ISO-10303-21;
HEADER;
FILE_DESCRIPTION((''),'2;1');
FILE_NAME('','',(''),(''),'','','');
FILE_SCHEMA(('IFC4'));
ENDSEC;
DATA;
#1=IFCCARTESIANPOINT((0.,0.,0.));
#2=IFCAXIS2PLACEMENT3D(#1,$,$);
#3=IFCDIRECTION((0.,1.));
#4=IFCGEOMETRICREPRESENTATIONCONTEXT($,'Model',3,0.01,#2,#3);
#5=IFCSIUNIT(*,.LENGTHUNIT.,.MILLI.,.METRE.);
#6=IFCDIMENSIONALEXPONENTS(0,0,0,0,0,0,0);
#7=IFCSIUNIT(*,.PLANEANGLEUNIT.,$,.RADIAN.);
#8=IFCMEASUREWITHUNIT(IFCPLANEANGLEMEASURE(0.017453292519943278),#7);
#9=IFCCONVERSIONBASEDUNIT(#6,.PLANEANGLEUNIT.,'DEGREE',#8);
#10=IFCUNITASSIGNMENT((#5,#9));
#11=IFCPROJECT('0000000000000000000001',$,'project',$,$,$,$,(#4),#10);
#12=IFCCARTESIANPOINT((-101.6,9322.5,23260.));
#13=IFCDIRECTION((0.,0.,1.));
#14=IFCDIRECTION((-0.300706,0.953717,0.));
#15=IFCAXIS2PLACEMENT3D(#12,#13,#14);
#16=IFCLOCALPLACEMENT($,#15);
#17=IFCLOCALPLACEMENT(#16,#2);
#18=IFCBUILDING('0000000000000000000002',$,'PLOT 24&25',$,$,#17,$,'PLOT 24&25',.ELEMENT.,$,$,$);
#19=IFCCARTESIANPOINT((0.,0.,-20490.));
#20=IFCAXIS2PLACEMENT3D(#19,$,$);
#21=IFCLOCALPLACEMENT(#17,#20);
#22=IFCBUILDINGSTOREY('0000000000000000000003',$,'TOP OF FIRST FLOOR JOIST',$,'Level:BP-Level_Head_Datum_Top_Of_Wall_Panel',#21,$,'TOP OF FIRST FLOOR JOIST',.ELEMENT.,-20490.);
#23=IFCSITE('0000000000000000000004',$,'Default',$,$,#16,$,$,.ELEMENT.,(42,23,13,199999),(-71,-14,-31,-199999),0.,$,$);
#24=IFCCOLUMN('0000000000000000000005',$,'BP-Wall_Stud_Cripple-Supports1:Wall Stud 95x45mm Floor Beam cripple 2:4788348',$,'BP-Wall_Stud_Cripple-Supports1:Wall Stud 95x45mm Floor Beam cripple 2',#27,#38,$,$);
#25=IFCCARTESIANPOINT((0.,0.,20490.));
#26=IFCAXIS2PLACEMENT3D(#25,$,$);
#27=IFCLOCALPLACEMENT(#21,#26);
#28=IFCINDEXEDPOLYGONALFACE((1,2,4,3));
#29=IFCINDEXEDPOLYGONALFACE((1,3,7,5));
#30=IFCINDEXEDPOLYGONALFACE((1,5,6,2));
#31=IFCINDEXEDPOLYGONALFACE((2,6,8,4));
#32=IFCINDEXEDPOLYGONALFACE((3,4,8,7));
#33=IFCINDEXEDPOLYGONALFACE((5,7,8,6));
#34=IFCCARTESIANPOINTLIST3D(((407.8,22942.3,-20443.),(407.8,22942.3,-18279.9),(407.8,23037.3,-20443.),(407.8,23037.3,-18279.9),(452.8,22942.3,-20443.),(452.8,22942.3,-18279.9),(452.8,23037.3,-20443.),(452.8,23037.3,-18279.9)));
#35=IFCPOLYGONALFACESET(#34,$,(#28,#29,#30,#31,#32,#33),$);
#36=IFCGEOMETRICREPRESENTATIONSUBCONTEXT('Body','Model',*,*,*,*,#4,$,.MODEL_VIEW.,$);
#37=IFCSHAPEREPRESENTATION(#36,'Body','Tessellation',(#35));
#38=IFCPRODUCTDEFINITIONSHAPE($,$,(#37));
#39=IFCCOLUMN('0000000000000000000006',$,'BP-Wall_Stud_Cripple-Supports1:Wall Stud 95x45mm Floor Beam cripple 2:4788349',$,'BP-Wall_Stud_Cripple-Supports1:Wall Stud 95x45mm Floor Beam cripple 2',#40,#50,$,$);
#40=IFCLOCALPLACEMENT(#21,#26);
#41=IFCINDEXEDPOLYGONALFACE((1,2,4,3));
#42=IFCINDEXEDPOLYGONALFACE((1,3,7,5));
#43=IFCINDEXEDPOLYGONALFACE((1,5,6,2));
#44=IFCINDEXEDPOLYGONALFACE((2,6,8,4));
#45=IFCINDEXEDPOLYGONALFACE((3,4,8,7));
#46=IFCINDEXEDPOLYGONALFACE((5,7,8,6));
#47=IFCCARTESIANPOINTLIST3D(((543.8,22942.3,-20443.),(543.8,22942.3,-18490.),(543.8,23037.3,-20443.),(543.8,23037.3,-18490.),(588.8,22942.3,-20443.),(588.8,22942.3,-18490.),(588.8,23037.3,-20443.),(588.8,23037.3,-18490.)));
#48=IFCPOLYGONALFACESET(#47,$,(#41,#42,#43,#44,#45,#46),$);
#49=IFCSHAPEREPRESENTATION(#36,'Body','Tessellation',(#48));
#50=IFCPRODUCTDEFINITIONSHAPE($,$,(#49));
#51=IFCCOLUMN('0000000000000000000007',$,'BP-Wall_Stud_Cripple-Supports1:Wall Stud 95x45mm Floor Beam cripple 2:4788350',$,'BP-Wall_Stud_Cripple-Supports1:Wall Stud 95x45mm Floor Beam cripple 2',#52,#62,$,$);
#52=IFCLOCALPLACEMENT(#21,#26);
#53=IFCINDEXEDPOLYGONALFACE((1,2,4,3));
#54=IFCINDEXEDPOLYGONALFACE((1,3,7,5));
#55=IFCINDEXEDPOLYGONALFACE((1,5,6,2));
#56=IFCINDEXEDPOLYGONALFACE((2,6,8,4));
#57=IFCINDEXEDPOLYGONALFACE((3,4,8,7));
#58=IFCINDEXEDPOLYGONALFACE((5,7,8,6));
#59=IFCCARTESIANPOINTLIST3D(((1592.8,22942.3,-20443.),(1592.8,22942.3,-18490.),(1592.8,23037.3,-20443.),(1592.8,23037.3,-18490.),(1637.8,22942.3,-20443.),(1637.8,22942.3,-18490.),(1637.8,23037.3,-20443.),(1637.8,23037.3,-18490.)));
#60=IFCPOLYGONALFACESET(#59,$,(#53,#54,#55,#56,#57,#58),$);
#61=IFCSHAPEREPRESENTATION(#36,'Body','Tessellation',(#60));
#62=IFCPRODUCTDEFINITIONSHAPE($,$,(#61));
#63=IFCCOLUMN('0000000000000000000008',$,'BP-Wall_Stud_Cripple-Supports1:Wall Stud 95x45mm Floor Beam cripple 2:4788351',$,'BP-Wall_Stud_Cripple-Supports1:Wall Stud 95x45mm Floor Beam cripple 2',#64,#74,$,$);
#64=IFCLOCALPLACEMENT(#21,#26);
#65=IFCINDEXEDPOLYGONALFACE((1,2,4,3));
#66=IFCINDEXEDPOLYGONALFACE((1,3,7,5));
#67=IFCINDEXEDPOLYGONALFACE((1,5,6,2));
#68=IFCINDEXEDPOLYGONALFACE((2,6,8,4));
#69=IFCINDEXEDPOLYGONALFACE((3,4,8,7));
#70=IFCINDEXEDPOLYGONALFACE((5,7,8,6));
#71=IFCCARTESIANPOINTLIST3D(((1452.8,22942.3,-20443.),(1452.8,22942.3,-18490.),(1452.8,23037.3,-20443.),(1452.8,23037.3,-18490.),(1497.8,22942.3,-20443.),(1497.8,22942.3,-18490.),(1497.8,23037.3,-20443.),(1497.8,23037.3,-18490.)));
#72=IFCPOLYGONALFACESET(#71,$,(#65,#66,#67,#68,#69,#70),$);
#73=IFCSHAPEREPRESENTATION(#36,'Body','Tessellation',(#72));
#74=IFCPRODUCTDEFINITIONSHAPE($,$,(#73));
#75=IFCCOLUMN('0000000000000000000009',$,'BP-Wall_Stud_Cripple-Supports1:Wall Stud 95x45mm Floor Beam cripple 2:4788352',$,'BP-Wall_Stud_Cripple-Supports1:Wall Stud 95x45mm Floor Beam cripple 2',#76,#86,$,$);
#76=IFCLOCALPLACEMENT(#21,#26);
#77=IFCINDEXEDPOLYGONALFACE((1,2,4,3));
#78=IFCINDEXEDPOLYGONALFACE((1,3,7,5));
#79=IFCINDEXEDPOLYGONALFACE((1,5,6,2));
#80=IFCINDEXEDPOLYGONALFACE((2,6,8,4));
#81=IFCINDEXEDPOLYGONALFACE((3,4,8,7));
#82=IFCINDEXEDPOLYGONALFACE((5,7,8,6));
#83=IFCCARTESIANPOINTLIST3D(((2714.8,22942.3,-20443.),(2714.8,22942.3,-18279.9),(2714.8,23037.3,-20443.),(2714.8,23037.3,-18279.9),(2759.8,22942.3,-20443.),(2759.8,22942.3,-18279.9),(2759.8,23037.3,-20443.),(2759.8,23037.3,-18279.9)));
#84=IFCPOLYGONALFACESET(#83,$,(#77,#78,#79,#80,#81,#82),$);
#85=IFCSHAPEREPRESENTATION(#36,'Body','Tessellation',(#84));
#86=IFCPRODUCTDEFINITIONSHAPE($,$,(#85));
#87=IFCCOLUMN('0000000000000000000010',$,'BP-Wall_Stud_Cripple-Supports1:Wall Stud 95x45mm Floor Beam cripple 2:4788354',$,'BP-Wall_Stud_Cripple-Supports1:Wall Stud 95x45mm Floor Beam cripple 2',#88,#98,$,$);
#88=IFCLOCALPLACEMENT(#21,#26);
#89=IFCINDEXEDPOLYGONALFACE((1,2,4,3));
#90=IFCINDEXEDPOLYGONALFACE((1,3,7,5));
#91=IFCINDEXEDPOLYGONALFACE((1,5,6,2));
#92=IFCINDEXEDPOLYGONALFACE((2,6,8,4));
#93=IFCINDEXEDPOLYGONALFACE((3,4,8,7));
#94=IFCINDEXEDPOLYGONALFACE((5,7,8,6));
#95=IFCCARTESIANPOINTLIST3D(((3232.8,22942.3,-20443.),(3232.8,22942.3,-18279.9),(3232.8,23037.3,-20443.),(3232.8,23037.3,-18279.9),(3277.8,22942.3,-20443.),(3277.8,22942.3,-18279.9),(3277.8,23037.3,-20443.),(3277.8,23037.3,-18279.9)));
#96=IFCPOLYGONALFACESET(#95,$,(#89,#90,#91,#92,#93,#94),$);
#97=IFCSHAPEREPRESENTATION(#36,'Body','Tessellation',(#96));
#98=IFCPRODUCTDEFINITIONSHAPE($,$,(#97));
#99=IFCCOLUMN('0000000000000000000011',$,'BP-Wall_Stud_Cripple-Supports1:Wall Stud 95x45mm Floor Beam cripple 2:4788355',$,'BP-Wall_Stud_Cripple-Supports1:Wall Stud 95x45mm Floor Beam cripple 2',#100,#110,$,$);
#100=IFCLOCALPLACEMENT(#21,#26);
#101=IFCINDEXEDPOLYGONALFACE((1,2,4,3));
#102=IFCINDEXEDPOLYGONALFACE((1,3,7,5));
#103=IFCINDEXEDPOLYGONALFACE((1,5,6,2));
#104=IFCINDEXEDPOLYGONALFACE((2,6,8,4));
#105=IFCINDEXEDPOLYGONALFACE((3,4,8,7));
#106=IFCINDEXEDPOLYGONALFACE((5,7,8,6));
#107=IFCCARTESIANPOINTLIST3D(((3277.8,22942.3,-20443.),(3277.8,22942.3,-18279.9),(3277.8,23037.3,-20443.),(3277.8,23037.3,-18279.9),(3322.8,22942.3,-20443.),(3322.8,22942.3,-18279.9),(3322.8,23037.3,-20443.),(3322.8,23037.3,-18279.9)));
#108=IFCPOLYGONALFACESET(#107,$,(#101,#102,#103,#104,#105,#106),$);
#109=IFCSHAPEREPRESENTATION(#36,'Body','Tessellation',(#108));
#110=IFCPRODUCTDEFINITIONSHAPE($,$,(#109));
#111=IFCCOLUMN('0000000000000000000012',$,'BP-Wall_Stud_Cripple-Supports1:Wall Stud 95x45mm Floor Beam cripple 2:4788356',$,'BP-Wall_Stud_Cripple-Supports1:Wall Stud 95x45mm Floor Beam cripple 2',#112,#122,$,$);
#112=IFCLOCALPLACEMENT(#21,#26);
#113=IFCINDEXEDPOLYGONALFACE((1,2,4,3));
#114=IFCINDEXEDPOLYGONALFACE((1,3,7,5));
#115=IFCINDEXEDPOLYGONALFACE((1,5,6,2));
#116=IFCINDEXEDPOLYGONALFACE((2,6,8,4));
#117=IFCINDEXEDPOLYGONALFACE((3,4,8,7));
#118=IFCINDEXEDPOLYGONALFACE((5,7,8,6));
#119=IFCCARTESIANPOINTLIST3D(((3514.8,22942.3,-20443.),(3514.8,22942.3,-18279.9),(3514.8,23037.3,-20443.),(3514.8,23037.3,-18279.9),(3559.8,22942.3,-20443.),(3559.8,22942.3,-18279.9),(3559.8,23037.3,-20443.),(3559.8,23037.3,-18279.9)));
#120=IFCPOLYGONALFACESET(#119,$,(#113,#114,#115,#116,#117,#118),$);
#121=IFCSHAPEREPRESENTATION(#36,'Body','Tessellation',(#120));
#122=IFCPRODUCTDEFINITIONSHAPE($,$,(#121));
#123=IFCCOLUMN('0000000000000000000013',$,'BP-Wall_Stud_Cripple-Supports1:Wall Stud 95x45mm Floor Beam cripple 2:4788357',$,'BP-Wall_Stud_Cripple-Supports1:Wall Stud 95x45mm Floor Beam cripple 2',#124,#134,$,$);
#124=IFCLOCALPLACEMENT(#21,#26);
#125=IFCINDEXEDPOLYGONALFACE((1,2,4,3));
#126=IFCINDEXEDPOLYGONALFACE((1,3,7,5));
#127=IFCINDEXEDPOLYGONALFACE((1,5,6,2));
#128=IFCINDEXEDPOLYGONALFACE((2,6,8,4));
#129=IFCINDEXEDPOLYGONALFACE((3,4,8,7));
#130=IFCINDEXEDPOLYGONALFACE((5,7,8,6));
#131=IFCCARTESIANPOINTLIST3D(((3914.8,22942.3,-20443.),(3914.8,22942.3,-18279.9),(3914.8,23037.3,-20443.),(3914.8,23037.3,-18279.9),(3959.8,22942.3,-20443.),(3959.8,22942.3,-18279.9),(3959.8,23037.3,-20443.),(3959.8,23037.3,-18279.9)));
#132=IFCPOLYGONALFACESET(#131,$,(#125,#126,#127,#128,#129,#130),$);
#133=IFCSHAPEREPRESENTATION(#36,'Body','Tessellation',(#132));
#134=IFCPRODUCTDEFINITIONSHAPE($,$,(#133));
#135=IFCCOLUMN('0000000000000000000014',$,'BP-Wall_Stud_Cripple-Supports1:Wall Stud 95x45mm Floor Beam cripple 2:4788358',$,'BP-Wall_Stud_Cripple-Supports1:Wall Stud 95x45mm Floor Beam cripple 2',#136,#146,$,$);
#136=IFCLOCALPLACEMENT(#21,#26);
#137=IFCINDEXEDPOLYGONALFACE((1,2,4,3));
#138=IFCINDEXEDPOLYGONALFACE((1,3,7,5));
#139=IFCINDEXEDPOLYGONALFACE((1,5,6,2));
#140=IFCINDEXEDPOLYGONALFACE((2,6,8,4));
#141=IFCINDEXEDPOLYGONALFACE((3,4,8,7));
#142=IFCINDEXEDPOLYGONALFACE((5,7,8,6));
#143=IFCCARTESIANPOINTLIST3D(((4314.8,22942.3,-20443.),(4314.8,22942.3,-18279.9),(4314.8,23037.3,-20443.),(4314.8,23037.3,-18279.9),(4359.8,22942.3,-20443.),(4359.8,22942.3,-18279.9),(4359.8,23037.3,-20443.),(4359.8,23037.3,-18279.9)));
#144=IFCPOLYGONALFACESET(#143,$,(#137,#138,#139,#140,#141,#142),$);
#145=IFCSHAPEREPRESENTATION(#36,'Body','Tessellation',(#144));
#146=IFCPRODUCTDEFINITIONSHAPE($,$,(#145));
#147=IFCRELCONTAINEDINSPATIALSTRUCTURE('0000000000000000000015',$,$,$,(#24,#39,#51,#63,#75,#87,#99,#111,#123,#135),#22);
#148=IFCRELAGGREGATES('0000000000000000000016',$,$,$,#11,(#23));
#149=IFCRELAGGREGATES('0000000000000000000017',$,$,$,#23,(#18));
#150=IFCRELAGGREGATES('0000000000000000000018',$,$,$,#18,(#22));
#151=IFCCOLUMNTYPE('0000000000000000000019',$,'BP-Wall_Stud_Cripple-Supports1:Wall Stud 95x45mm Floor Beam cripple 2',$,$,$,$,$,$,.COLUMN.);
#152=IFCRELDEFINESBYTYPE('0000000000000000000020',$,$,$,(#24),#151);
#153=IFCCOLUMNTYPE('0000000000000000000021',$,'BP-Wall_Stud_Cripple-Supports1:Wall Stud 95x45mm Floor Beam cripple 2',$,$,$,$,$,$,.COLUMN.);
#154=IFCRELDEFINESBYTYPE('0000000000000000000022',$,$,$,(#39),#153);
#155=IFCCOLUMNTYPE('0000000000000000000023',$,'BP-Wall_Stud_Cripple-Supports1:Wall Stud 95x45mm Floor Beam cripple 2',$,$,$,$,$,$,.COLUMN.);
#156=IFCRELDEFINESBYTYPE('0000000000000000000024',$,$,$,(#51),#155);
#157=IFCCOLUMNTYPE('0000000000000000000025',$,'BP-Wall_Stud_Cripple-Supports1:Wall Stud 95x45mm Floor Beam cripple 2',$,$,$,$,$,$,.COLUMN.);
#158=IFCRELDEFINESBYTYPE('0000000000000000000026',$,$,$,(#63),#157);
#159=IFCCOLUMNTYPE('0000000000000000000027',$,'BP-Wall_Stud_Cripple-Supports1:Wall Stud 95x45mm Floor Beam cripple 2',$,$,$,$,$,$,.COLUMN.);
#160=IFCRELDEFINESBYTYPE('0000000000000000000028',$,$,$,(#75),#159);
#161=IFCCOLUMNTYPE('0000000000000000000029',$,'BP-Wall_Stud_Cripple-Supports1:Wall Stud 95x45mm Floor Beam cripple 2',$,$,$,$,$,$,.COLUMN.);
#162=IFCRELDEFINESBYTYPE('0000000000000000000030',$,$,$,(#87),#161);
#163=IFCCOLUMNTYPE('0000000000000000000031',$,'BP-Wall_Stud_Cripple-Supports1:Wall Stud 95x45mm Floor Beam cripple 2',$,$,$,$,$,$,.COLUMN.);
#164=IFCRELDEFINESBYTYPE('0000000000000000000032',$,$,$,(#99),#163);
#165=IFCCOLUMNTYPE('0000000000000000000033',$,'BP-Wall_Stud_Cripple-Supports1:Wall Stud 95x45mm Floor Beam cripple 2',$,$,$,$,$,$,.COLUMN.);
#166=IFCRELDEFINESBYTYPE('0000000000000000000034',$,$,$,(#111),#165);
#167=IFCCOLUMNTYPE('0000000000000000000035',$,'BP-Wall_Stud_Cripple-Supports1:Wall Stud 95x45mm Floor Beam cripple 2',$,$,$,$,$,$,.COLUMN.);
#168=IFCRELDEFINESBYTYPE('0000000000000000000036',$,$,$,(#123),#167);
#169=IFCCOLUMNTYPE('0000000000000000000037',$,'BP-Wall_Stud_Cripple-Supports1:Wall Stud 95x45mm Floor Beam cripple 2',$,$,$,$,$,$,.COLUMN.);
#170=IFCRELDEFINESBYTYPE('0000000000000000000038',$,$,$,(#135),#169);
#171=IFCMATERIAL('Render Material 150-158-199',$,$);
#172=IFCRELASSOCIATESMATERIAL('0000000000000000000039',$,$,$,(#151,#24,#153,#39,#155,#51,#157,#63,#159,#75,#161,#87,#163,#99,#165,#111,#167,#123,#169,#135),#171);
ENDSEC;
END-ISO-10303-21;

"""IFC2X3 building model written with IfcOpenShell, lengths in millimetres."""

from ifc_helpers import new_model, entity, si_unit, converted_unit, direction, frame, frame_2d, origin, place, context, subcontext, project, spatial, rectangle, extrude, source, transform, mapped, material, type_object, type_shapes, element, save


model = new_model("IFC2X3")

# Units and contexts
model_context = context("Model", 3, precision=0.01, world=origin(), true_north=direction((0.0, 1.0)))
body_context = subcontext(model_context, "Body", "Model", "MODEL_VIEW")
ifc_project = project(units=[si_unit("LENGTHUNIT", "METRE", prefix="MILLI"), converted_unit("PLANEANGLEUNIT", "DEGREE", entity("IfcPlaneAngleMeasure", 0.017453292519943278), si_unit("PLANEANGLEUNIT", "RADIAN"), dimensions=[0, 0, 0, 0, 0, 0, 0])], contexts=[model_context])

# Site, building, storey
site_placement = place(None, frame((-101.6, 9322.5, 23260.0), z_axis=(0.0, 0.0, 1.0), x_axis=(-0.300706, 0.953717, 0.0)))
site = spatial("IfcSite", under=ifc_project, at=site_placement, Name="Default", CompositionType="ELEMENT", RefLatitude=(42, 23, 13, 199999), RefLongitude=(-71, -14, -31, -199999), RefElevation=0.0)
building_placement = place(site_placement, origin())
building = spatial("IfcBuilding", under=site, at=building_placement, Name="PLOT 24&25", LongName="PLOT 24&25", CompositionType="ELEMENT")
storey_placement = place(building_placement, frame((0.0, 0.0, -20490.0)))
storey = spatial("IfcBuildingStorey", under=building, at=storey_placement, Name="TOP OF FIRST FLOOR JOIST", ObjectType="Level:BP-Level_Head_Datum_Top_Of_Wall_Panel", LongName="TOP OF FIRST FLOOR JOIST", CompositionType="ELEMENT", Elevation=-20490.0)

# Columns
ifc_material_1 = material(Name="Render Material 150-158-199")
column_type_1 = type_object("IfcColumnType", Name="BP-Wall_Stud_Cripple-Supports1:Wall Stud 95x45mm Floor Beam cripple 2", PredefinedType="COLUMN", material=ifc_material_1)
shared_shape_1 = source(origin(), body_context, "Body", "SweptSolid", [
    extrude(rectangle(XDim=45.0, YDim=95.0, at=frame_2d((0.0, 0.0), x_axis=(1.0, 0.0))), frame((430.3, 22989.8, -20443.0), z_axis=(0.0, 0.0, 1.0), x_axis=(-1.0, 0.0, 0.0)), (0.0, 0.0, 1.0), 2163.1),
])
type_shapes(column_type_1, [shared_shape_1])
column_1_placement = place(storey_placement, frame((0.0, 0.0, 20490.0)))
element("IfcColumn", 1, at=column_1_placement, inside=storey, type_object=column_type_1, material=ifc_material_1, Name="BP-Wall_Stud_Cripple-Supports1:Wall Stud 95x45mm Floor Beam cripple 2:4788348", ObjectType="BP-Wall_Stud_Cripple-Supports1:Wall Stud 95x45mm Floor Beam cripple 2", context=body_context, shape_type="MappedRepresentation", body=[
    mapped(shared_shape_1, transform((0.0, 0.0, 0.0), scale=1.0)),
])
column_type_2 = type_object("IfcColumnType", Name="BP-Wall_Stud_Cripple-Supports1:Wall Stud 95x45mm Floor Beam cripple 2", PredefinedType="COLUMN", material=ifc_material_1)
shared_shape_2 = source(origin(), body_context, "Body", "SweptSolid", [
    extrude(rectangle(XDim=45.0, YDim=95.0, at=frame_2d((0.0, 0.0), x_axis=(1.0, 0.0))), frame((566.3, 22989.8, -20443.0), z_axis=(0.0, 0.0, 1.0), x_axis=(-1.0, 0.0, 0.0)), (0.0, 0.0, 1.0), 1953.0),
])
type_shapes(column_type_2, [shared_shape_2])
column_2_placement = place(storey_placement, frame((0.0, 0.0, 20490.0)))
element("IfcColumn", 2, at=column_2_placement, inside=storey, type_object=column_type_2, material=ifc_material_1, Name="BP-Wall_Stud_Cripple-Supports1:Wall Stud 95x45mm Floor Beam cripple 2:4788349", ObjectType="BP-Wall_Stud_Cripple-Supports1:Wall Stud 95x45mm Floor Beam cripple 2", context=body_context, shape_type="MappedRepresentation", body=[
    mapped(shared_shape_2, transform((0.0, 0.0, 0.0), scale=1.0)),
])
column_type_3 = type_object("IfcColumnType", Name="BP-Wall_Stud_Cripple-Supports1:Wall Stud 95x45mm Floor Beam cripple 2", PredefinedType="COLUMN", material=ifc_material_1)
shared_shape_3 = source(origin(), body_context, "Body", "SweptSolid", [
    extrude(rectangle(XDim=45.0, YDim=95.0, at=frame_2d((0.0, 0.0), x_axis=(1.0, 0.0))), frame((1615.3, 22989.8, -20443.0), z_axis=(0.0, 0.0, 1.0), x_axis=(-1.0, 0.0, 0.0)), (0.0, 0.0, 1.0), 1953.0),
])
type_shapes(column_type_3, [shared_shape_3])
column_3_placement = place(storey_placement, frame((0.0, 0.0, 20490.0)))
element("IfcColumn", 3, at=column_3_placement, inside=storey, type_object=column_type_3, material=ifc_material_1, Name="BP-Wall_Stud_Cripple-Supports1:Wall Stud 95x45mm Floor Beam cripple 2:4788350", ObjectType="BP-Wall_Stud_Cripple-Supports1:Wall Stud 95x45mm Floor Beam cripple 2", context=body_context, shape_type="MappedRepresentation", body=[
    mapped(shared_shape_3, transform((0.0, 0.0, 0.0), scale=1.0)),
])
column_type_4 = type_object("IfcColumnType", Name="BP-Wall_Stud_Cripple-Supports1:Wall Stud 95x45mm Floor Beam cripple 2", PredefinedType="COLUMN", material=ifc_material_1)
shared_shape_4 = source(origin(), body_context, "Body", "SweptSolid", [
    extrude(rectangle(XDim=45.0, YDim=95.0, at=frame_2d((0.0, 0.0), x_axis=(1.0, 0.0))), frame((1475.3, 22989.8, -20443.0), z_axis=(0.0, 0.0, 1.0), x_axis=(-1.0, 0.0, 0.0)), (0.0, 0.0, 1.0), 1953.0),
])
type_shapes(column_type_4, [shared_shape_4])
column_4_placement = place(storey_placement, frame((0.0, 0.0, 20490.0)))
element("IfcColumn", 4, at=column_4_placement, inside=storey, type_object=column_type_4, material=ifc_material_1, Name="BP-Wall_Stud_Cripple-Supports1:Wall Stud 95x45mm Floor Beam cripple 2:4788351", ObjectType="BP-Wall_Stud_Cripple-Supports1:Wall Stud 95x45mm Floor Beam cripple 2", context=body_context, shape_type="MappedRepresentation", body=[
    mapped(shared_shape_4, transform((0.0, 0.0, 0.0), scale=1.0)),
])
column_type_5 = type_object("IfcColumnType", Name="BP-Wall_Stud_Cripple-Supports1:Wall Stud 95x45mm Floor Beam cripple 2", PredefinedType="COLUMN", material=ifc_material_1)
shared_shape_5 = source(origin(), body_context, "Body", "SweptSolid", [
    extrude(rectangle(XDim=45.0, YDim=95.0, at=frame_2d((0.0, 0.0), x_axis=(1.0, 0.0))), frame((2737.3, 22989.8, -20443.0), z_axis=(0.0, 0.0, 1.0), x_axis=(-1.0, 0.0, 0.0)), (0.0, 0.0, 1.0), 2163.1),
])
type_shapes(column_type_5, [shared_shape_5])
column_5_placement = place(storey_placement, frame((0.0, 0.0, 20490.0)))
element("IfcColumn", 5, at=column_5_placement, inside=storey, type_object=column_type_5, material=ifc_material_1, Name="BP-Wall_Stud_Cripple-Supports1:Wall Stud 95x45mm Floor Beam cripple 2:4788352", ObjectType="BP-Wall_Stud_Cripple-Supports1:Wall Stud 95x45mm Floor Beam cripple 2", context=body_context, shape_type="MappedRepresentation", body=[
    mapped(shared_shape_5, transform((0.0, 0.0, 0.0), scale=1.0)),
])
column_type_6 = type_object("IfcColumnType", Name="BP-Wall_Stud_Cripple-Supports1:Wall Stud 95x45mm Floor Beam cripple 2", PredefinedType="COLUMN", material=ifc_material_1)
shared_shape_6 = source(origin(), body_context, "Body", "SweptSolid", [
    extrude(rectangle(XDim=45.0, YDim=95.0, at=frame_2d((0.0, 0.0), x_axis=(1.0, 0.0))), frame((3255.3, 22989.8, -20443.0), z_axis=(0.0, 0.0, 1.0), x_axis=(-1.0, 0.0, 0.0)), (0.0, 0.0, 1.0), 2163.1),
])
type_shapes(column_type_6, [shared_shape_6])
column_6_placement = place(storey_placement, frame((0.0, 0.0, 20490.0)))
element("IfcColumn", 6, at=column_6_placement, inside=storey, type_object=column_type_6, material=ifc_material_1, Name="BP-Wall_Stud_Cripple-Supports1:Wall Stud 95x45mm Floor Beam cripple 2:4788354", ObjectType="BP-Wall_Stud_Cripple-Supports1:Wall Stud 95x45mm Floor Beam cripple 2", context=body_context, shape_type="MappedRepresentation", body=[
    mapped(shared_shape_6, transform((0.0, 0.0, 0.0), scale=1.0)),
])
column_type_7 = type_object("IfcColumnType", Name="BP-Wall_Stud_Cripple-Supports1:Wall Stud 95x45mm Floor Beam cripple 2", PredefinedType="COLUMN", material=ifc_material_1)
shared_shape_7 = source(origin(), body_context, "Body", "SweptSolid", [
    extrude(rectangle(XDim=45.0, YDim=95.0, at=frame_2d((0.0, 0.0), x_axis=(1.0, 0.0))), frame((3300.3, 22989.8, -20443.0), z_axis=(0.0, 0.0, 1.0), x_axis=(-1.0, 0.0, 0.0)), (0.0, 0.0, 1.0), 2163.1),
])
type_shapes(column_type_7, [shared_shape_7])
column_7_placement = place(storey_placement, frame((0.0, 0.0, 20490.0)))
element("IfcColumn", 7, at=column_7_placement, inside=storey, type_object=column_type_7, material=ifc_material_1, Name="BP-Wall_Stud_Cripple-Supports1:Wall Stud 95x45mm Floor Beam cripple 2:4788355", ObjectType="BP-Wall_Stud_Cripple-Supports1:Wall Stud 95x45mm Floor Beam cripple 2", context=body_context, shape_type="MappedRepresentation", body=[
    mapped(shared_shape_7, transform((0.0, 0.0, 0.0), scale=1.0)),
])
column_type_8 = type_object("IfcColumnType", Name="BP-Wall_Stud_Cripple-Supports1:Wall Stud 95x45mm Floor Beam cripple 2", PredefinedType="COLUMN", material=ifc_material_1)
shared_shape_8 = source(origin(), body_context, "Body", "SweptSolid", [
    extrude(rectangle(XDim=45.0, YDim=95.0, at=frame_2d((0.0, 0.0), x_axis=(1.0, 0.0))), frame((3537.3, 22989.8, -20443.0), z_axis=(0.0, 0.0, 1.0), x_axis=(-1.0, 0.0, 0.0)), (0.0, 0.0, 1.0), 2163.1),
])
type_shapes(column_type_8, [shared_shape_8])
column_8_placement = place(storey_placement, frame((0.0, 0.0, 20490.0)))
element("IfcColumn", 8, at=column_8_placement, inside=storey, type_object=column_type_8, material=ifc_material_1, Name="BP-Wall_Stud_Cripple-Supports1:Wall Stud 95x45mm Floor Beam cripple 2:4788356", ObjectType="BP-Wall_Stud_Cripple-Supports1:Wall Stud 95x45mm Floor Beam cripple 2", context=body_context, shape_type="MappedRepresentation", body=[
    mapped(shared_shape_8, transform((0.0, 0.0, 0.0), scale=1.0)),
])
column_type_9 = type_object("IfcColumnType", Name="BP-Wall_Stud_Cripple-Supports1:Wall Stud 95x45mm Floor Beam cripple 2", PredefinedType="COLUMN", material=ifc_material_1)
shared_shape_9 = source(origin(), body_context, "Body", "SweptSolid", [
    extrude(rectangle(XDim=45.0, YDim=95.0, at=frame_2d((0.0, 0.0), x_axis=(1.0, 0.0))), frame((3937.3, 22989.8, -20443.0), z_axis=(0.0, 0.0, 1.0), x_axis=(-1.0, 0.0, 0.0)), (0.0, 0.0, 1.0), 2163.1),
])
type_shapes(column_type_9, [shared_shape_9])
column_9_placement = place(storey_placement, frame((0.0, 0.0, 20490.0)))
element("IfcColumn", 9, at=column_9_placement, inside=storey, type_object=column_type_9, material=ifc_material_1, Name="BP-Wall_Stud_Cripple-Supports1:Wall Stud 95x45mm Floor Beam cripple 2:4788357", ObjectType="BP-Wall_Stud_Cripple-Supports1:Wall Stud 95x45mm Floor Beam cripple 2", context=body_context, shape_type="MappedRepresentation", body=[
    mapped(shared_shape_9, transform((0.0, 0.0, 0.0), scale=1.0)),
])
column_type_10 = type_object("IfcColumnType", Name="BP-Wall_Stud_Cripple-Supports1:Wall Stud 95x45mm Floor Beam cripple 2", PredefinedType="COLUMN", material=ifc_material_1)
shared_shape_10 = source(origin(), body_context, "Body", "SweptSolid", [
    extrude(rectangle(XDim=45.0, YDim=95.0, at=frame_2d((0.0, 0.0), x_axis=(1.0, 0.0))), frame((4337.3, 22989.8, -20443.0), z_axis=(0.0, 0.0, 1.0), x_axis=(-1.0, 0.0, 0.0)), (0.0, 0.0, 1.0), 2163.1),
])
type_shapes(column_type_10, [shared_shape_10])
column_10_placement = place(storey_placement, frame((0.0, 0.0, 20490.0)))
element("IfcColumn", 10, at=column_10_placement, inside=storey, type_object=column_type_10, material=ifc_material_1, Name="BP-Wall_Stud_Cripple-Supports1:Wall Stud 95x45mm Floor Beam cripple 2:4788358", ObjectType="BP-Wall_Stud_Cripple-Supports1:Wall Stud 95x45mm Floor Beam cripple 2", context=body_context, shape_type="MappedRepresentation", body=[
    mapped(shared_shape_10, transform((0.0, 0.0, 0.0), scale=1.0)),
])

save(model, "model.ifc")
